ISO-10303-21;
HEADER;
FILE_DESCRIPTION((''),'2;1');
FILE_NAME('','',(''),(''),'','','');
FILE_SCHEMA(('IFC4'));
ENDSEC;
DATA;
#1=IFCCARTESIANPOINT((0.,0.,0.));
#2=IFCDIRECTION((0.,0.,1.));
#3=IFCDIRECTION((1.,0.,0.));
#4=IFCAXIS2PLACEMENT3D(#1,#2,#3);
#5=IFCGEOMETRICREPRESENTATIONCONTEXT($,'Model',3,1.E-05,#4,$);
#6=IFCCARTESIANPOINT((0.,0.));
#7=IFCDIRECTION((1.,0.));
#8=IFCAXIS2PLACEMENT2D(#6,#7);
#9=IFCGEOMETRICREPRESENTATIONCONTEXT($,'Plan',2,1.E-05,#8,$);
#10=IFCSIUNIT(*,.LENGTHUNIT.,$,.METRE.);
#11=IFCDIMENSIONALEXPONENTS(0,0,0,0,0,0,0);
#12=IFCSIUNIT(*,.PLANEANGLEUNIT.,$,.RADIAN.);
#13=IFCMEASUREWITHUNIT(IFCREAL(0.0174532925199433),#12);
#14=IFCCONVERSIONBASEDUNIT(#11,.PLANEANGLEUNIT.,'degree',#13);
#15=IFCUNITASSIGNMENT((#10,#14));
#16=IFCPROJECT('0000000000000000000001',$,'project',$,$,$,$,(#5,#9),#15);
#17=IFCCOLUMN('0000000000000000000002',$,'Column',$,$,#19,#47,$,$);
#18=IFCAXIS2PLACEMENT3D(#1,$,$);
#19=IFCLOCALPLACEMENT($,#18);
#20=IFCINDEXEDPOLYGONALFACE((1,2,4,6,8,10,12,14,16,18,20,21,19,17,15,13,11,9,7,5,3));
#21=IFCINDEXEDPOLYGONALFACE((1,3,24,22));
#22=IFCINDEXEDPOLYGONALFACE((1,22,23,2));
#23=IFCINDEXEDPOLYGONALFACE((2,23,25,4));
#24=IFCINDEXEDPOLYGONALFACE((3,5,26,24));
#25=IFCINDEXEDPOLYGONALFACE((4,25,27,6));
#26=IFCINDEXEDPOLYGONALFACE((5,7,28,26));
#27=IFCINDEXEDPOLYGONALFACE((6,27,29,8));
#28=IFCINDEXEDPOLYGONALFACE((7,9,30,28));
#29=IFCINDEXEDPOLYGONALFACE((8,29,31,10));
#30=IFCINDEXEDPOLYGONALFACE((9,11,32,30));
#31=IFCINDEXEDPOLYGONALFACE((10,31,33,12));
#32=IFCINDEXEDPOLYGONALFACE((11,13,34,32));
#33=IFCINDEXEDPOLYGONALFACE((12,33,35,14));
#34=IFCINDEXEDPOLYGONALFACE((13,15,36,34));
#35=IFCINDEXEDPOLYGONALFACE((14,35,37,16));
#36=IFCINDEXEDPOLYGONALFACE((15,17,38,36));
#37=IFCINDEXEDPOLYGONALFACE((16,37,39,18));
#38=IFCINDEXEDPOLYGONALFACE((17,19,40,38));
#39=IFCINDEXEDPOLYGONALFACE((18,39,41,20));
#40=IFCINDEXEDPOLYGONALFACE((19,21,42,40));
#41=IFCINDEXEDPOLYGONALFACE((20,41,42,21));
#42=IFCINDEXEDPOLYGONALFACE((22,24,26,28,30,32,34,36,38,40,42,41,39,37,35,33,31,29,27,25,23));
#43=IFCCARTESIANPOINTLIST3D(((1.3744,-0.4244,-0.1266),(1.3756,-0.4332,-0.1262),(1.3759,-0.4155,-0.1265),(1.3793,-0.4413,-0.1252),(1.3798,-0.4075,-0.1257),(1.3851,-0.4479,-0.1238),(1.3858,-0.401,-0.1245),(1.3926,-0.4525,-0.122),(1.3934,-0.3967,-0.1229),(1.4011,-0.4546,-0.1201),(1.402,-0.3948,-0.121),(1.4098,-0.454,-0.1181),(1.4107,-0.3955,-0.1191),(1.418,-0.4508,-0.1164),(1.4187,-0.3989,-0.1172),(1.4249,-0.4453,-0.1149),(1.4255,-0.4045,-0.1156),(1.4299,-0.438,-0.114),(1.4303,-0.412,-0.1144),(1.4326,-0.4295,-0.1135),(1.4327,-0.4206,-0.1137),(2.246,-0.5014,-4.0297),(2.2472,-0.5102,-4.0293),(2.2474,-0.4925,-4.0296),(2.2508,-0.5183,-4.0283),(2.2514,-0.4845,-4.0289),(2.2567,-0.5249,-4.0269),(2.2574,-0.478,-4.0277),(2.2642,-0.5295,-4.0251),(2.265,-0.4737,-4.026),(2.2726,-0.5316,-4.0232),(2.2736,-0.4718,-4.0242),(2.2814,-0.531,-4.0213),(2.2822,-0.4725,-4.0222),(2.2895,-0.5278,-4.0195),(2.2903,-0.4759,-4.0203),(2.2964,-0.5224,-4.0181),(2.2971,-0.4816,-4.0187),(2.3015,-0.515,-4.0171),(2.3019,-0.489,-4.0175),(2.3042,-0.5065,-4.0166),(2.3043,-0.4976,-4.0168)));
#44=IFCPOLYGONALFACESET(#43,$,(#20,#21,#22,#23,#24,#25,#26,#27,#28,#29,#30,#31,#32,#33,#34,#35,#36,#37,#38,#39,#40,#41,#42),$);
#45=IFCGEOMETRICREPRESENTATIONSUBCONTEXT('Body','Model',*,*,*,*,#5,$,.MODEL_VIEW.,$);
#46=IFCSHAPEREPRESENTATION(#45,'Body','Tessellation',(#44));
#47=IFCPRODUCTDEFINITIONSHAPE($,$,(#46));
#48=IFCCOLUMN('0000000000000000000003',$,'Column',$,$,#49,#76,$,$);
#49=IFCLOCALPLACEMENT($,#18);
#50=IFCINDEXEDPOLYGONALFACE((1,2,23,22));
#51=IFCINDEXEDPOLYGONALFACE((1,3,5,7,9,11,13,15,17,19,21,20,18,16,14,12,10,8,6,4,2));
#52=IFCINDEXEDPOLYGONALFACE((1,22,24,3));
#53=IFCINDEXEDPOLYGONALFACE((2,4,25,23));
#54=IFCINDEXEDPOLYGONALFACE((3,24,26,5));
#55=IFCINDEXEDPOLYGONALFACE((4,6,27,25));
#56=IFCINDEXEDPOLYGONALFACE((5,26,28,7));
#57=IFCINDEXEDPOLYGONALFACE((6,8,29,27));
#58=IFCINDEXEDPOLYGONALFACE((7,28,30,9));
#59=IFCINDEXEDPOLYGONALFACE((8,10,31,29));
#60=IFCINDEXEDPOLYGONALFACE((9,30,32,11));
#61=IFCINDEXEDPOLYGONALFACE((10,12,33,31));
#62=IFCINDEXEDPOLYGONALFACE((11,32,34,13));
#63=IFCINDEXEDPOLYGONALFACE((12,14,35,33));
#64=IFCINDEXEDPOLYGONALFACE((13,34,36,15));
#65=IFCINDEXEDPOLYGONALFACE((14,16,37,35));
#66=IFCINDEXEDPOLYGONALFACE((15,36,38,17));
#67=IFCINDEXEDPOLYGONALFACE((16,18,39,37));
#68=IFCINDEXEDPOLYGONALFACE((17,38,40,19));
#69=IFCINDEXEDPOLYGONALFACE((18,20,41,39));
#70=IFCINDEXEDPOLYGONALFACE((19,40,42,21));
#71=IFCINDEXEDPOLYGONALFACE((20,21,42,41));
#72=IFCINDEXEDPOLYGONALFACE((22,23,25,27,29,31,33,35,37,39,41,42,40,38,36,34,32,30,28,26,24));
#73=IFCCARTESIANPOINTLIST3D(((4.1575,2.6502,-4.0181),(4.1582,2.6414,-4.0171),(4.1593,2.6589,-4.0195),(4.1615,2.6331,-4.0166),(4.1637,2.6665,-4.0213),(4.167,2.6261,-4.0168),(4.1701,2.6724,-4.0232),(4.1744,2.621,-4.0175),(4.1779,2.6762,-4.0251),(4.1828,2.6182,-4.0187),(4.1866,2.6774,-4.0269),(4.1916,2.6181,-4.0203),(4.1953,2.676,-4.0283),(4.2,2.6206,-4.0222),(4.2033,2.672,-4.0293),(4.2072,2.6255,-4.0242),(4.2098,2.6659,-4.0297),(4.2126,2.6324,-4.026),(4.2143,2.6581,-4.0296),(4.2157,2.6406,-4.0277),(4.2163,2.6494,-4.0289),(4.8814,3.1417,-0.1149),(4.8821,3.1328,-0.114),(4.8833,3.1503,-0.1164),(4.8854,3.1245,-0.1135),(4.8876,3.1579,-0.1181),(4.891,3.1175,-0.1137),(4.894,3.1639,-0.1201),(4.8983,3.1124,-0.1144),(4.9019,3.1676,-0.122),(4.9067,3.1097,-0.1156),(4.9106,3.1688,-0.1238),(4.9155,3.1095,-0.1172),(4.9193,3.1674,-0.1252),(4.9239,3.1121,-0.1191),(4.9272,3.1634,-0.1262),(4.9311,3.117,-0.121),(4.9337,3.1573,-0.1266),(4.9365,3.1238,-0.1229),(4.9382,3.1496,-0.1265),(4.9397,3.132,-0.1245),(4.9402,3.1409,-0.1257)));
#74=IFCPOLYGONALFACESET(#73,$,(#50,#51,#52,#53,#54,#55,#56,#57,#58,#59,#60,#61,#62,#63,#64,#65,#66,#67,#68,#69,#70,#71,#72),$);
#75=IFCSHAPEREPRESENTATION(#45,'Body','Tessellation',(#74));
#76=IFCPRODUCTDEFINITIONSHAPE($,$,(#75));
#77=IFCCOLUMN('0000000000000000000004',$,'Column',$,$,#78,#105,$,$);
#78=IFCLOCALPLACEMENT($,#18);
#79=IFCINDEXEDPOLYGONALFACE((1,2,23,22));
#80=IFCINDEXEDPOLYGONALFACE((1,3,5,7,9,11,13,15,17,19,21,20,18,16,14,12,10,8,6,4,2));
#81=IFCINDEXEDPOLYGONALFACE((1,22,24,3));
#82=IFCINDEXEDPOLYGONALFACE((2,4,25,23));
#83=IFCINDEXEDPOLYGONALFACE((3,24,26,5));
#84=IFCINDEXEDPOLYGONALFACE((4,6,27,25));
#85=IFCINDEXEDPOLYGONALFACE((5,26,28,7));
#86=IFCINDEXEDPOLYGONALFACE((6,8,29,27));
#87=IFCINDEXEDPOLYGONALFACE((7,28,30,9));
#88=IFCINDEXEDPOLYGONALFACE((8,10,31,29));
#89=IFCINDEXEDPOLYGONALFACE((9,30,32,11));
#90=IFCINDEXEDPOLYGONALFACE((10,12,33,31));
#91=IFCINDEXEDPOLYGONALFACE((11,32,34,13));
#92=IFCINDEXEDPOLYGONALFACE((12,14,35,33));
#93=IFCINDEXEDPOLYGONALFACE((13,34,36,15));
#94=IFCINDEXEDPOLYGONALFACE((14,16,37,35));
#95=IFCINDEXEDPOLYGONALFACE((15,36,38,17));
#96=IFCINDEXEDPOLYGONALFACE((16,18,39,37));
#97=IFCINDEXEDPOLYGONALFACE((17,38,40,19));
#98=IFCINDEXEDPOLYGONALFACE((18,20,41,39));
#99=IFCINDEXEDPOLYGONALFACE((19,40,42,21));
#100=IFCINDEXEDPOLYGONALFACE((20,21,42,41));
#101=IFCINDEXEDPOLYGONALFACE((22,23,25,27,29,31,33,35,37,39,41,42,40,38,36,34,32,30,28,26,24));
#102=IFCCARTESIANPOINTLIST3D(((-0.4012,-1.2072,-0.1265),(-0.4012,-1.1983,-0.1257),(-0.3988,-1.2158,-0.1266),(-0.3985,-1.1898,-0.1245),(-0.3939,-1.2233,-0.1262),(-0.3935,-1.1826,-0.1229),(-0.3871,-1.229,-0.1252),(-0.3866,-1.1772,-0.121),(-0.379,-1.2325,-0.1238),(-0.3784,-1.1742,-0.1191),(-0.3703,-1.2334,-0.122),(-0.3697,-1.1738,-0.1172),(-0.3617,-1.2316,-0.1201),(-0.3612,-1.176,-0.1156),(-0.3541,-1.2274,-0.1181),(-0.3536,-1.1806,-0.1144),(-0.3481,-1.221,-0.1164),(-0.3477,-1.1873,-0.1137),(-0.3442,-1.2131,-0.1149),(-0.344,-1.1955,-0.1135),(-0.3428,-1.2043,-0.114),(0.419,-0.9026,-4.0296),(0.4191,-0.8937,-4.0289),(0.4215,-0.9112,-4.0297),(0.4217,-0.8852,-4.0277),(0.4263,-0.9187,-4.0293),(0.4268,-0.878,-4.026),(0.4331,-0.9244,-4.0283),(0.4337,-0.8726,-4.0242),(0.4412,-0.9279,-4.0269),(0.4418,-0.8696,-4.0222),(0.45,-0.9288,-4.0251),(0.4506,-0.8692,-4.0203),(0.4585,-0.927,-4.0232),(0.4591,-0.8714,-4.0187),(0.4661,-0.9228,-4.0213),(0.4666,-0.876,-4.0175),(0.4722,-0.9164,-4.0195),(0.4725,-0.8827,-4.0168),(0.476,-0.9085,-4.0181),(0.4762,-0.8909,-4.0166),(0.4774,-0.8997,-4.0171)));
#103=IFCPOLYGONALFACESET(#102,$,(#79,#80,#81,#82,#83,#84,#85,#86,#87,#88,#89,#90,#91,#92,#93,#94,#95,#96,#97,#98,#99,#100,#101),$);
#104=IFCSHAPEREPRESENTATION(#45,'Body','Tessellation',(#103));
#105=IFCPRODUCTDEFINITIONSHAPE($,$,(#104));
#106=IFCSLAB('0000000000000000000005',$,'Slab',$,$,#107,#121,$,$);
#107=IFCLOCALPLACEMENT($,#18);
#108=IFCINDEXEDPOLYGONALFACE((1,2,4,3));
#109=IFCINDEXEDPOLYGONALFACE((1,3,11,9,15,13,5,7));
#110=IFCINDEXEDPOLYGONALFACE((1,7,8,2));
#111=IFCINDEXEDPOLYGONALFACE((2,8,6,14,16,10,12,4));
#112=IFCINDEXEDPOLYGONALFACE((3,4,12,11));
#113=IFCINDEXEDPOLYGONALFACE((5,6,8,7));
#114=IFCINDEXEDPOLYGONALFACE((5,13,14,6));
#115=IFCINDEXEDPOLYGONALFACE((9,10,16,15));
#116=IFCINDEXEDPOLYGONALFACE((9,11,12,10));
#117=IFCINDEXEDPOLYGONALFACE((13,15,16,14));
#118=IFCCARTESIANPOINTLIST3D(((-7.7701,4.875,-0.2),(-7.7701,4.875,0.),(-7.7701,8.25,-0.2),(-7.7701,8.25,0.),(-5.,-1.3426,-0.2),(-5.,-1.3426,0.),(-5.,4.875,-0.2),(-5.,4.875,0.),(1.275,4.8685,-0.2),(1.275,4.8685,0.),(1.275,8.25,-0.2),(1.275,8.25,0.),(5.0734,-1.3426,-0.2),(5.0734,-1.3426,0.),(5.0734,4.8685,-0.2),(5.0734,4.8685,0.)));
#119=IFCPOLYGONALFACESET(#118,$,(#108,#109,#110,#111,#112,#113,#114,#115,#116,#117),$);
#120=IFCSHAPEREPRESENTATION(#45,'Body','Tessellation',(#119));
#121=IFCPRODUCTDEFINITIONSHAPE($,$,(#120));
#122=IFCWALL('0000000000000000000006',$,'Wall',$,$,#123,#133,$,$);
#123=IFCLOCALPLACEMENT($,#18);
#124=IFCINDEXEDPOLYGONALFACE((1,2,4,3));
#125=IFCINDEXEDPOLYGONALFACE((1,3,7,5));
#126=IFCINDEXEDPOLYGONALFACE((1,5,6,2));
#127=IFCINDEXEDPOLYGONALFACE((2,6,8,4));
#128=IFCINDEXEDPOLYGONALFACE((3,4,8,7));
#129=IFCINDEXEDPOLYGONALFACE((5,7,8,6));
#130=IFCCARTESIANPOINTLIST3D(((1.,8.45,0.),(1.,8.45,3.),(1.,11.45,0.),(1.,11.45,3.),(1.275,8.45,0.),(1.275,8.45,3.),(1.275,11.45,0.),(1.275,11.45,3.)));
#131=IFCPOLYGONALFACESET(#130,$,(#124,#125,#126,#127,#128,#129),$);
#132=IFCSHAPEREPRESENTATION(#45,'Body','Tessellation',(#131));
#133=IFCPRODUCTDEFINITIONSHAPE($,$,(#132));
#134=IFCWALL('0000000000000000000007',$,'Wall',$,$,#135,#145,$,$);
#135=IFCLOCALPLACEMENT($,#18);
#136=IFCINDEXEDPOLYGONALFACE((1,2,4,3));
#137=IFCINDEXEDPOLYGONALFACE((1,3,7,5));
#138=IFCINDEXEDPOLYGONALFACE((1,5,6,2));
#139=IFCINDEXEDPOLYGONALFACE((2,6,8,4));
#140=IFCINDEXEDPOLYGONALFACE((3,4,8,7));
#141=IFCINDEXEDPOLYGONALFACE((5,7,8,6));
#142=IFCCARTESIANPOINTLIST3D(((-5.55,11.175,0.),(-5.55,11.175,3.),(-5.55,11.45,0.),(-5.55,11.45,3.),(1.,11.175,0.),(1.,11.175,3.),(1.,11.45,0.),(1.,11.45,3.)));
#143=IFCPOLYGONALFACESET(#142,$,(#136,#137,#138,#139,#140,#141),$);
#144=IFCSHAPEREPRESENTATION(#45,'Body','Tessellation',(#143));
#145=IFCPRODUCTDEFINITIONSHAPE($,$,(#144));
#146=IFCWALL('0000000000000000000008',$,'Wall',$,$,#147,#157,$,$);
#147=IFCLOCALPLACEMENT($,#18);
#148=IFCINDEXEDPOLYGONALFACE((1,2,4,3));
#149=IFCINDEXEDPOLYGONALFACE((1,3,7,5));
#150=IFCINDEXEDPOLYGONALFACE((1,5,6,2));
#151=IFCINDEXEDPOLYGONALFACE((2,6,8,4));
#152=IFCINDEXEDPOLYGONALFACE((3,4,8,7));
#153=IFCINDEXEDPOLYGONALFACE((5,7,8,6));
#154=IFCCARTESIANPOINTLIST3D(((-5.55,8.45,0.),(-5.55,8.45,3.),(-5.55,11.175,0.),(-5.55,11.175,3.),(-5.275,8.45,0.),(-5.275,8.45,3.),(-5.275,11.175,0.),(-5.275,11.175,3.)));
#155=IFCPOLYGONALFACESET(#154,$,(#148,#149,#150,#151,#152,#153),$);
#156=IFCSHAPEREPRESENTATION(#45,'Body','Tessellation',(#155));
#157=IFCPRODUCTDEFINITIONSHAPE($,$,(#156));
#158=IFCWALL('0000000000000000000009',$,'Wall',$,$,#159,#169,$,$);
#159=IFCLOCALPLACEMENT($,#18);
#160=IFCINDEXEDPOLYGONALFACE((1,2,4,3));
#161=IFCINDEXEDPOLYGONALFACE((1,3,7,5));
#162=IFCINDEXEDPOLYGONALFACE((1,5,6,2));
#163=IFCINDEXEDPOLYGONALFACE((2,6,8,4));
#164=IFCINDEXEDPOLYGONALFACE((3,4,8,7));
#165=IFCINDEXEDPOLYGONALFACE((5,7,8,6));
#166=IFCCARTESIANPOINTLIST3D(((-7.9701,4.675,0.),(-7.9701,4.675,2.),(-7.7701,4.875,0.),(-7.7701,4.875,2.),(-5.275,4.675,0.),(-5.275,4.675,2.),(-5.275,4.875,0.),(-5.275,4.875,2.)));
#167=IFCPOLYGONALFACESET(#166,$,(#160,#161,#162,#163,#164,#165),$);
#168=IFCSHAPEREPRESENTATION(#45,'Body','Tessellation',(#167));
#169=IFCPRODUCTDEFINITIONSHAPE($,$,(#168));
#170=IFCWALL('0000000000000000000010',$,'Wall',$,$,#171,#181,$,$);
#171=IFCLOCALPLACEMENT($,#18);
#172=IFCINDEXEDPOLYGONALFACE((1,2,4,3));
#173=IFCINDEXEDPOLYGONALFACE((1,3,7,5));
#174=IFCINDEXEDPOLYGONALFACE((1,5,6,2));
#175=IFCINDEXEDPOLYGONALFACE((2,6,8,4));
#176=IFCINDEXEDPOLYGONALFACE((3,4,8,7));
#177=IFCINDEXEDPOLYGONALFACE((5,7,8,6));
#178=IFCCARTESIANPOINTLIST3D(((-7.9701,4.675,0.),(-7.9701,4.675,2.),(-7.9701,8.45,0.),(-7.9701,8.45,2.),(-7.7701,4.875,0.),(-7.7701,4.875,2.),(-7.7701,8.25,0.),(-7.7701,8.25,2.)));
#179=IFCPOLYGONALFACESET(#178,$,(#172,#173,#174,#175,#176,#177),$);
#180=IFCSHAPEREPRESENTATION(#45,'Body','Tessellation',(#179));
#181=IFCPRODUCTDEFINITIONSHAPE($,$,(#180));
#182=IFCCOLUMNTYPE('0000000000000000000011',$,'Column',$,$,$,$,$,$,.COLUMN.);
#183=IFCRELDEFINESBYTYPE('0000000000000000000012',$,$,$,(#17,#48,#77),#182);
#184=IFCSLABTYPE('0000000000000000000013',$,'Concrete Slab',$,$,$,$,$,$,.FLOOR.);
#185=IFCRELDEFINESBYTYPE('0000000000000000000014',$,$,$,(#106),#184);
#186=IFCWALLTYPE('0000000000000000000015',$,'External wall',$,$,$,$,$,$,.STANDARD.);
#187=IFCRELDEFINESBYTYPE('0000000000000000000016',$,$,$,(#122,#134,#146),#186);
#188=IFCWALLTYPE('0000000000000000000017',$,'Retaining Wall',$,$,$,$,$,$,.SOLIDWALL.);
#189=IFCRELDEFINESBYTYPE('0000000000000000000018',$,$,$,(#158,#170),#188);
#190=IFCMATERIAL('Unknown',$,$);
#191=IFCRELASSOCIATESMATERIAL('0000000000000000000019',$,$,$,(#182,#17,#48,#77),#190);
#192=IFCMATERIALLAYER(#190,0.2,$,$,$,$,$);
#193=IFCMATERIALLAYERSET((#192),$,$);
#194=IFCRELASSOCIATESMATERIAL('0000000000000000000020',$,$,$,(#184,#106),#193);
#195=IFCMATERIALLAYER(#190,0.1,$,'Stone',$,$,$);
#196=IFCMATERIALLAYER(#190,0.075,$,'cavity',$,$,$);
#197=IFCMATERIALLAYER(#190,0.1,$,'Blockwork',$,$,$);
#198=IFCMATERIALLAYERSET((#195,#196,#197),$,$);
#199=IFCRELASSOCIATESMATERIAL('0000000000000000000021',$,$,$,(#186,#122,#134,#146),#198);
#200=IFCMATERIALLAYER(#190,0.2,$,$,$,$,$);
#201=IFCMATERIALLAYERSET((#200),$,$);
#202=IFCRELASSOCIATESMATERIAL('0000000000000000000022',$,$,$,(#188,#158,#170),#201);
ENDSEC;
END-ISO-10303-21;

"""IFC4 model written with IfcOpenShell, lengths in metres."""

from ifc_helpers import new_model, entity, si_unit, converted_unit, frame, origin_with_axes, origin_2d_with_axis, place, context, subcontext, project, line, indexed_curve, circle, outline, extrude, clip, halfspace, material, layer, layer_set, layer_usage, material_profile, profile_set, profile_usage, type_object, element, save


model = new_model("IFC4")

# Units and contexts
model_context = context("Model", 3, precision=1e-05, world=origin_with_axes())
plan_context = context("Plan", 2, precision=1e-05, world=origin_2d_with_axis())
body_context = subcontext(model_context, "Body", "Model", "MODEL_VIEW")
ifc_project = project(units=[si_unit("LENGTHUNIT", "METRE"), converted_unit("PLANEANGLEUNIT", "degree", entity("IfcReal", 0.0174532925199433), si_unit("PLANEANGLEUNIT", "RADIAN"), dimensions=[0, 0, 0, 0, 0, 0, 0])], contexts=[model_context, plan_context])

# Columns
ifc_material = material(Name="Unknown")
ifc_material_profile = material_profile(ifc_material, circle(Radius=0.03))
ifc_profile_set = profile_set([ifc_material_profile])
column_type = type_object("IfcColumnType", Name="Column", PredefinedType="COLUMN", material=ifc_profile_set)
ifc_profile_usage_1 = profile_usage(ifc_profile_set, cardinal=5)
column_1_placement = place(None, frame((2.2753, -0.5017, -4.0232), z_axis=(-0.217892, 0.019251, 0.975783), x_axis=(-0.088007, -0.99612, 0.0)))
element("IfcColumn", 1, at=column_1_placement, type_object=column_type, material=ifc_profile_usage_1, Name="Column", context=body_context, shape_type="SweptSolid", body=[
    extrude(circle(Radius=0.03), origin_with_axes(), (0.0, 0.0, 1.0), 4.0),
])
ifc_profile_usage_2 = profile_usage(ifc_profile_set, cardinal=5)
column_2_placement = place(None, frame((4.1869, 2.6476, -4.0232), z_axis=(0.18098, 0.122856, 0.975783), x_axis=(-0.561651, 0.827374, 0.0)))
element("IfcColumn", 2, at=column_2_placement, type_object=column_type, material=ifc_profile_usage_2, Name="Column", context=body_context, shape_type="SweptSolid", body=[
    extrude(circle(Radius=0.03), origin_with_axes(), (0.0, 0.0, 1.0), 4.0),
])
ifc_profile_usage_3 = profile_usage(ifc_profile_set, cardinal=5)
column_3_placement = place(None, frame((0.4481, -0.8989, -4.0232), z_axis=(-0.205058, -0.076149, 0.975783), x_axis=(0.348124, -0.937448, 0.0)))
element("IfcColumn", 3, at=column_3_placement, type_object=column_type, material=ifc_profile_usage_3, Name="Column", context=body_context, shape_type="SweptSolid", body=[
    extrude(circle(Radius=0.03), origin_with_axes(), (0.0, 0.0, 1.0), 4.0),
])

# Slab
ifc_layer_1 = layer(ifc_material, 0.2)
ifc_layer_set_1 = layer_set([ifc_layer_1])
ifc_layer_usage_1 = layer_usage(ifc_layer_set_1, "AXIS3", "POSITIVE", 0.0)
slab_type = type_object("IfcSlabType", Name="Concrete Slab", PredefinedType="FLOOR", material=ifc_layer_set_1)
slab_placement = place(None, frame((1.275, 0.0, -0.2), z_axis=(0.0, 0.0, 1.0), x_axis=(1.0, 0.0, 0.0)))
element("IfcSlab", 4, at=slab_placement, type_object=slab_type, material=ifc_layer_usage_1, Name="Slab", context=body_context, shape_type="SweptSolid", body=[
    extrude(outline(indexed_curve([(0.0, 8.25), (-9.0451, 8.25), (-9.0451, 4.875), (-6.275, 4.875), (-6.275, -1.3426), (3.7984, -1.3426), (3.7984, 4.8685), (0.0, 4.8685)], segments=[line(5, 6), line(6, 7), line(7, 8), line(8, 1), line(1, 2), line(2, 3), line(3, 4), line(4, 5)], self_intersect=False)), None, (0.0, 0.0, 1.0), 0.2),
])

# Walls
ifc_layer_2 = layer(ifc_material, 0.1, Name="Stone")
ifc_layer_3 = layer(ifc_material, 0.075, Name="cavity")
ifc_layer_4 = layer(ifc_material, 0.1, Name="Blockwork")
ifc_layer_set_2 = layer_set([ifc_layer_2, ifc_layer_3, ifc_layer_4])
ifc_layer_usage_2 = layer_usage(ifc_layer_set_2, "AXIS2", "POSITIVE", 0.0)
wall_type_1 = type_object("IfcWallType", Name="External wall", PredefinedType="STANDARD", material=ifc_layer_set_2)
wall_1_placement = place(None, frame((1.275, 8.45, 0.0), z_axis=(0.0, 0.0, 1.0), x_axis=(0.0, 1.0, 0.0)))
element("IfcWall", 5, at=wall_1_placement, type_object=wall_type_1, material=ifc_layer_usage_2, Name="Wall", context=body_context, shape_type="SweptSolid", body=[
    extrude(outline(indexed_curve([(0.0, 0.0), (0.0, 0.275), (3.0, 0.275), (3.0, 0.0), (0.0, 0.0)], self_intersect=False)), origin_with_axes(), (0.0, 0.0, 1.0), 3.0),
])
ifc_layer_usage_3 = layer_usage(ifc_layer_set_2, "AXIS2", "POSITIVE", 0.0)
wall_2_placement = place(None, frame((1.0, 11.45, 0.0), z_axis=(0.0, 0.0, 1.0), x_axis=(-1.0, 0.0, 0.0)))
element("IfcWall", 6, at=wall_2_placement, type_object=wall_type_1, material=ifc_layer_usage_3, Name="Wall", context=body_context, shape_type="SweptSolid", body=[
    extrude(outline(indexed_curve([(0.0, 0.0), (0.0, 0.275), (6.55, 0.275), (6.55, 0.0), (0.0, 0.0)], self_intersect=False)), origin_with_axes(), (0.0, 0.0, 1.0), 3.0),
])
ifc_layer_usage_4 = layer_usage(ifc_layer_set_2, "AXIS2", "POSITIVE", 0.0)
wall_3_placement = place(None, frame((-5.275, 8.45, 0.0), z_axis=(0.0, 0.0, 1.0), x_axis=(0.0, 1.0, 0.0)))
element("IfcWall", 7, at=wall_3_placement, type_object=wall_type_1, material=ifc_layer_usage_4, Name="Wall", context=body_context, shape_type="SweptSolid", body=[
    extrude(outline(indexed_curve([(0.0, 0.0), (0.0, 0.275), (2.725, 0.275), (2.725, 0.0), (0.0, 0.0)], self_intersect=False)), origin_with_axes(), (0.0, 0.0, 1.0), 3.0),
])
ifc_layer_5 = layer(ifc_material, 0.2)
ifc_layer_set_3 = layer_set([ifc_layer_5])
ifc_layer_usage_5 = layer_usage(ifc_layer_set_3, "AXIS2", "POSITIVE", 0.0)
wall_type_2 = type_object("IfcWallType", Name="Retaining Wall", PredefinedType="SOLIDWALL", material=ifc_layer_set_3)
wall_4_placement = place(None, frame((-7.9701, 4.675, 0.0), z_axis=(0.0, 0.0, 1.0), x_axis=(1.0, 0.0, 0.0)))
element("IfcWall", 8, at=wall_4_placement, type_object=wall_type_2, material=ifc_layer_usage_5, Name="Wall", context=body_context, shape_type="Clipping", body=[
    clip(extrude(outline(indexed_curve([(0.0, 0.0), (0.0, 0.2), (2.6951, 0.2), (2.6951, 0.0), (0.0, 0.0)], self_intersect=False)), origin_with_axes(), (0.0, 0.0, 1.0), 2.0), halfspace(frame((0.0, 0.0, 0.0), z_axis=(-0.707108, 0.707106, 0.0), x_axis=(0.707106, 0.707108, 0.0)), False)),
])
ifc_layer_usage_6 = layer_usage(ifc_layer_set_3, "AXIS2", "POSITIVE", 0.0)
wall_5_placement = place(None, frame((-7.9701, 8.45, 0.0), z_axis=(0.0, 0.0, 1.0), x_axis=(0.0, -1.0, 0.0)))
element("IfcWall", 9, at=wall_5_placement, type_object=wall_type_2, material=ifc_layer_usage_6, Name="Wall", context=body_context, shape_type="Clipping", body=[
    clip(clip(extrude(outline(indexed_curve([(0.0, 0.0), (0.0, 0.2), (3.775, 0.2), (3.775, 0.0), (0.0, 0.0)], self_intersect=False)), origin_with_axes(), (0.0, 0.0, 1.0), 2.0), halfspace(frame((0.0, 0.0, 0.0), z_axis=(-0.707106, 0.707107, 0.0), x_axis=(0.707107, 0.707107, 0.0)), False)), halfspace(frame((3.775, 0.0, 0.0), z_axis=(0.707106, 0.707107, 0.0), x_axis=(0.707107, -0.707106, 0.0)), False)),
])

save(model, "model.ifc")
